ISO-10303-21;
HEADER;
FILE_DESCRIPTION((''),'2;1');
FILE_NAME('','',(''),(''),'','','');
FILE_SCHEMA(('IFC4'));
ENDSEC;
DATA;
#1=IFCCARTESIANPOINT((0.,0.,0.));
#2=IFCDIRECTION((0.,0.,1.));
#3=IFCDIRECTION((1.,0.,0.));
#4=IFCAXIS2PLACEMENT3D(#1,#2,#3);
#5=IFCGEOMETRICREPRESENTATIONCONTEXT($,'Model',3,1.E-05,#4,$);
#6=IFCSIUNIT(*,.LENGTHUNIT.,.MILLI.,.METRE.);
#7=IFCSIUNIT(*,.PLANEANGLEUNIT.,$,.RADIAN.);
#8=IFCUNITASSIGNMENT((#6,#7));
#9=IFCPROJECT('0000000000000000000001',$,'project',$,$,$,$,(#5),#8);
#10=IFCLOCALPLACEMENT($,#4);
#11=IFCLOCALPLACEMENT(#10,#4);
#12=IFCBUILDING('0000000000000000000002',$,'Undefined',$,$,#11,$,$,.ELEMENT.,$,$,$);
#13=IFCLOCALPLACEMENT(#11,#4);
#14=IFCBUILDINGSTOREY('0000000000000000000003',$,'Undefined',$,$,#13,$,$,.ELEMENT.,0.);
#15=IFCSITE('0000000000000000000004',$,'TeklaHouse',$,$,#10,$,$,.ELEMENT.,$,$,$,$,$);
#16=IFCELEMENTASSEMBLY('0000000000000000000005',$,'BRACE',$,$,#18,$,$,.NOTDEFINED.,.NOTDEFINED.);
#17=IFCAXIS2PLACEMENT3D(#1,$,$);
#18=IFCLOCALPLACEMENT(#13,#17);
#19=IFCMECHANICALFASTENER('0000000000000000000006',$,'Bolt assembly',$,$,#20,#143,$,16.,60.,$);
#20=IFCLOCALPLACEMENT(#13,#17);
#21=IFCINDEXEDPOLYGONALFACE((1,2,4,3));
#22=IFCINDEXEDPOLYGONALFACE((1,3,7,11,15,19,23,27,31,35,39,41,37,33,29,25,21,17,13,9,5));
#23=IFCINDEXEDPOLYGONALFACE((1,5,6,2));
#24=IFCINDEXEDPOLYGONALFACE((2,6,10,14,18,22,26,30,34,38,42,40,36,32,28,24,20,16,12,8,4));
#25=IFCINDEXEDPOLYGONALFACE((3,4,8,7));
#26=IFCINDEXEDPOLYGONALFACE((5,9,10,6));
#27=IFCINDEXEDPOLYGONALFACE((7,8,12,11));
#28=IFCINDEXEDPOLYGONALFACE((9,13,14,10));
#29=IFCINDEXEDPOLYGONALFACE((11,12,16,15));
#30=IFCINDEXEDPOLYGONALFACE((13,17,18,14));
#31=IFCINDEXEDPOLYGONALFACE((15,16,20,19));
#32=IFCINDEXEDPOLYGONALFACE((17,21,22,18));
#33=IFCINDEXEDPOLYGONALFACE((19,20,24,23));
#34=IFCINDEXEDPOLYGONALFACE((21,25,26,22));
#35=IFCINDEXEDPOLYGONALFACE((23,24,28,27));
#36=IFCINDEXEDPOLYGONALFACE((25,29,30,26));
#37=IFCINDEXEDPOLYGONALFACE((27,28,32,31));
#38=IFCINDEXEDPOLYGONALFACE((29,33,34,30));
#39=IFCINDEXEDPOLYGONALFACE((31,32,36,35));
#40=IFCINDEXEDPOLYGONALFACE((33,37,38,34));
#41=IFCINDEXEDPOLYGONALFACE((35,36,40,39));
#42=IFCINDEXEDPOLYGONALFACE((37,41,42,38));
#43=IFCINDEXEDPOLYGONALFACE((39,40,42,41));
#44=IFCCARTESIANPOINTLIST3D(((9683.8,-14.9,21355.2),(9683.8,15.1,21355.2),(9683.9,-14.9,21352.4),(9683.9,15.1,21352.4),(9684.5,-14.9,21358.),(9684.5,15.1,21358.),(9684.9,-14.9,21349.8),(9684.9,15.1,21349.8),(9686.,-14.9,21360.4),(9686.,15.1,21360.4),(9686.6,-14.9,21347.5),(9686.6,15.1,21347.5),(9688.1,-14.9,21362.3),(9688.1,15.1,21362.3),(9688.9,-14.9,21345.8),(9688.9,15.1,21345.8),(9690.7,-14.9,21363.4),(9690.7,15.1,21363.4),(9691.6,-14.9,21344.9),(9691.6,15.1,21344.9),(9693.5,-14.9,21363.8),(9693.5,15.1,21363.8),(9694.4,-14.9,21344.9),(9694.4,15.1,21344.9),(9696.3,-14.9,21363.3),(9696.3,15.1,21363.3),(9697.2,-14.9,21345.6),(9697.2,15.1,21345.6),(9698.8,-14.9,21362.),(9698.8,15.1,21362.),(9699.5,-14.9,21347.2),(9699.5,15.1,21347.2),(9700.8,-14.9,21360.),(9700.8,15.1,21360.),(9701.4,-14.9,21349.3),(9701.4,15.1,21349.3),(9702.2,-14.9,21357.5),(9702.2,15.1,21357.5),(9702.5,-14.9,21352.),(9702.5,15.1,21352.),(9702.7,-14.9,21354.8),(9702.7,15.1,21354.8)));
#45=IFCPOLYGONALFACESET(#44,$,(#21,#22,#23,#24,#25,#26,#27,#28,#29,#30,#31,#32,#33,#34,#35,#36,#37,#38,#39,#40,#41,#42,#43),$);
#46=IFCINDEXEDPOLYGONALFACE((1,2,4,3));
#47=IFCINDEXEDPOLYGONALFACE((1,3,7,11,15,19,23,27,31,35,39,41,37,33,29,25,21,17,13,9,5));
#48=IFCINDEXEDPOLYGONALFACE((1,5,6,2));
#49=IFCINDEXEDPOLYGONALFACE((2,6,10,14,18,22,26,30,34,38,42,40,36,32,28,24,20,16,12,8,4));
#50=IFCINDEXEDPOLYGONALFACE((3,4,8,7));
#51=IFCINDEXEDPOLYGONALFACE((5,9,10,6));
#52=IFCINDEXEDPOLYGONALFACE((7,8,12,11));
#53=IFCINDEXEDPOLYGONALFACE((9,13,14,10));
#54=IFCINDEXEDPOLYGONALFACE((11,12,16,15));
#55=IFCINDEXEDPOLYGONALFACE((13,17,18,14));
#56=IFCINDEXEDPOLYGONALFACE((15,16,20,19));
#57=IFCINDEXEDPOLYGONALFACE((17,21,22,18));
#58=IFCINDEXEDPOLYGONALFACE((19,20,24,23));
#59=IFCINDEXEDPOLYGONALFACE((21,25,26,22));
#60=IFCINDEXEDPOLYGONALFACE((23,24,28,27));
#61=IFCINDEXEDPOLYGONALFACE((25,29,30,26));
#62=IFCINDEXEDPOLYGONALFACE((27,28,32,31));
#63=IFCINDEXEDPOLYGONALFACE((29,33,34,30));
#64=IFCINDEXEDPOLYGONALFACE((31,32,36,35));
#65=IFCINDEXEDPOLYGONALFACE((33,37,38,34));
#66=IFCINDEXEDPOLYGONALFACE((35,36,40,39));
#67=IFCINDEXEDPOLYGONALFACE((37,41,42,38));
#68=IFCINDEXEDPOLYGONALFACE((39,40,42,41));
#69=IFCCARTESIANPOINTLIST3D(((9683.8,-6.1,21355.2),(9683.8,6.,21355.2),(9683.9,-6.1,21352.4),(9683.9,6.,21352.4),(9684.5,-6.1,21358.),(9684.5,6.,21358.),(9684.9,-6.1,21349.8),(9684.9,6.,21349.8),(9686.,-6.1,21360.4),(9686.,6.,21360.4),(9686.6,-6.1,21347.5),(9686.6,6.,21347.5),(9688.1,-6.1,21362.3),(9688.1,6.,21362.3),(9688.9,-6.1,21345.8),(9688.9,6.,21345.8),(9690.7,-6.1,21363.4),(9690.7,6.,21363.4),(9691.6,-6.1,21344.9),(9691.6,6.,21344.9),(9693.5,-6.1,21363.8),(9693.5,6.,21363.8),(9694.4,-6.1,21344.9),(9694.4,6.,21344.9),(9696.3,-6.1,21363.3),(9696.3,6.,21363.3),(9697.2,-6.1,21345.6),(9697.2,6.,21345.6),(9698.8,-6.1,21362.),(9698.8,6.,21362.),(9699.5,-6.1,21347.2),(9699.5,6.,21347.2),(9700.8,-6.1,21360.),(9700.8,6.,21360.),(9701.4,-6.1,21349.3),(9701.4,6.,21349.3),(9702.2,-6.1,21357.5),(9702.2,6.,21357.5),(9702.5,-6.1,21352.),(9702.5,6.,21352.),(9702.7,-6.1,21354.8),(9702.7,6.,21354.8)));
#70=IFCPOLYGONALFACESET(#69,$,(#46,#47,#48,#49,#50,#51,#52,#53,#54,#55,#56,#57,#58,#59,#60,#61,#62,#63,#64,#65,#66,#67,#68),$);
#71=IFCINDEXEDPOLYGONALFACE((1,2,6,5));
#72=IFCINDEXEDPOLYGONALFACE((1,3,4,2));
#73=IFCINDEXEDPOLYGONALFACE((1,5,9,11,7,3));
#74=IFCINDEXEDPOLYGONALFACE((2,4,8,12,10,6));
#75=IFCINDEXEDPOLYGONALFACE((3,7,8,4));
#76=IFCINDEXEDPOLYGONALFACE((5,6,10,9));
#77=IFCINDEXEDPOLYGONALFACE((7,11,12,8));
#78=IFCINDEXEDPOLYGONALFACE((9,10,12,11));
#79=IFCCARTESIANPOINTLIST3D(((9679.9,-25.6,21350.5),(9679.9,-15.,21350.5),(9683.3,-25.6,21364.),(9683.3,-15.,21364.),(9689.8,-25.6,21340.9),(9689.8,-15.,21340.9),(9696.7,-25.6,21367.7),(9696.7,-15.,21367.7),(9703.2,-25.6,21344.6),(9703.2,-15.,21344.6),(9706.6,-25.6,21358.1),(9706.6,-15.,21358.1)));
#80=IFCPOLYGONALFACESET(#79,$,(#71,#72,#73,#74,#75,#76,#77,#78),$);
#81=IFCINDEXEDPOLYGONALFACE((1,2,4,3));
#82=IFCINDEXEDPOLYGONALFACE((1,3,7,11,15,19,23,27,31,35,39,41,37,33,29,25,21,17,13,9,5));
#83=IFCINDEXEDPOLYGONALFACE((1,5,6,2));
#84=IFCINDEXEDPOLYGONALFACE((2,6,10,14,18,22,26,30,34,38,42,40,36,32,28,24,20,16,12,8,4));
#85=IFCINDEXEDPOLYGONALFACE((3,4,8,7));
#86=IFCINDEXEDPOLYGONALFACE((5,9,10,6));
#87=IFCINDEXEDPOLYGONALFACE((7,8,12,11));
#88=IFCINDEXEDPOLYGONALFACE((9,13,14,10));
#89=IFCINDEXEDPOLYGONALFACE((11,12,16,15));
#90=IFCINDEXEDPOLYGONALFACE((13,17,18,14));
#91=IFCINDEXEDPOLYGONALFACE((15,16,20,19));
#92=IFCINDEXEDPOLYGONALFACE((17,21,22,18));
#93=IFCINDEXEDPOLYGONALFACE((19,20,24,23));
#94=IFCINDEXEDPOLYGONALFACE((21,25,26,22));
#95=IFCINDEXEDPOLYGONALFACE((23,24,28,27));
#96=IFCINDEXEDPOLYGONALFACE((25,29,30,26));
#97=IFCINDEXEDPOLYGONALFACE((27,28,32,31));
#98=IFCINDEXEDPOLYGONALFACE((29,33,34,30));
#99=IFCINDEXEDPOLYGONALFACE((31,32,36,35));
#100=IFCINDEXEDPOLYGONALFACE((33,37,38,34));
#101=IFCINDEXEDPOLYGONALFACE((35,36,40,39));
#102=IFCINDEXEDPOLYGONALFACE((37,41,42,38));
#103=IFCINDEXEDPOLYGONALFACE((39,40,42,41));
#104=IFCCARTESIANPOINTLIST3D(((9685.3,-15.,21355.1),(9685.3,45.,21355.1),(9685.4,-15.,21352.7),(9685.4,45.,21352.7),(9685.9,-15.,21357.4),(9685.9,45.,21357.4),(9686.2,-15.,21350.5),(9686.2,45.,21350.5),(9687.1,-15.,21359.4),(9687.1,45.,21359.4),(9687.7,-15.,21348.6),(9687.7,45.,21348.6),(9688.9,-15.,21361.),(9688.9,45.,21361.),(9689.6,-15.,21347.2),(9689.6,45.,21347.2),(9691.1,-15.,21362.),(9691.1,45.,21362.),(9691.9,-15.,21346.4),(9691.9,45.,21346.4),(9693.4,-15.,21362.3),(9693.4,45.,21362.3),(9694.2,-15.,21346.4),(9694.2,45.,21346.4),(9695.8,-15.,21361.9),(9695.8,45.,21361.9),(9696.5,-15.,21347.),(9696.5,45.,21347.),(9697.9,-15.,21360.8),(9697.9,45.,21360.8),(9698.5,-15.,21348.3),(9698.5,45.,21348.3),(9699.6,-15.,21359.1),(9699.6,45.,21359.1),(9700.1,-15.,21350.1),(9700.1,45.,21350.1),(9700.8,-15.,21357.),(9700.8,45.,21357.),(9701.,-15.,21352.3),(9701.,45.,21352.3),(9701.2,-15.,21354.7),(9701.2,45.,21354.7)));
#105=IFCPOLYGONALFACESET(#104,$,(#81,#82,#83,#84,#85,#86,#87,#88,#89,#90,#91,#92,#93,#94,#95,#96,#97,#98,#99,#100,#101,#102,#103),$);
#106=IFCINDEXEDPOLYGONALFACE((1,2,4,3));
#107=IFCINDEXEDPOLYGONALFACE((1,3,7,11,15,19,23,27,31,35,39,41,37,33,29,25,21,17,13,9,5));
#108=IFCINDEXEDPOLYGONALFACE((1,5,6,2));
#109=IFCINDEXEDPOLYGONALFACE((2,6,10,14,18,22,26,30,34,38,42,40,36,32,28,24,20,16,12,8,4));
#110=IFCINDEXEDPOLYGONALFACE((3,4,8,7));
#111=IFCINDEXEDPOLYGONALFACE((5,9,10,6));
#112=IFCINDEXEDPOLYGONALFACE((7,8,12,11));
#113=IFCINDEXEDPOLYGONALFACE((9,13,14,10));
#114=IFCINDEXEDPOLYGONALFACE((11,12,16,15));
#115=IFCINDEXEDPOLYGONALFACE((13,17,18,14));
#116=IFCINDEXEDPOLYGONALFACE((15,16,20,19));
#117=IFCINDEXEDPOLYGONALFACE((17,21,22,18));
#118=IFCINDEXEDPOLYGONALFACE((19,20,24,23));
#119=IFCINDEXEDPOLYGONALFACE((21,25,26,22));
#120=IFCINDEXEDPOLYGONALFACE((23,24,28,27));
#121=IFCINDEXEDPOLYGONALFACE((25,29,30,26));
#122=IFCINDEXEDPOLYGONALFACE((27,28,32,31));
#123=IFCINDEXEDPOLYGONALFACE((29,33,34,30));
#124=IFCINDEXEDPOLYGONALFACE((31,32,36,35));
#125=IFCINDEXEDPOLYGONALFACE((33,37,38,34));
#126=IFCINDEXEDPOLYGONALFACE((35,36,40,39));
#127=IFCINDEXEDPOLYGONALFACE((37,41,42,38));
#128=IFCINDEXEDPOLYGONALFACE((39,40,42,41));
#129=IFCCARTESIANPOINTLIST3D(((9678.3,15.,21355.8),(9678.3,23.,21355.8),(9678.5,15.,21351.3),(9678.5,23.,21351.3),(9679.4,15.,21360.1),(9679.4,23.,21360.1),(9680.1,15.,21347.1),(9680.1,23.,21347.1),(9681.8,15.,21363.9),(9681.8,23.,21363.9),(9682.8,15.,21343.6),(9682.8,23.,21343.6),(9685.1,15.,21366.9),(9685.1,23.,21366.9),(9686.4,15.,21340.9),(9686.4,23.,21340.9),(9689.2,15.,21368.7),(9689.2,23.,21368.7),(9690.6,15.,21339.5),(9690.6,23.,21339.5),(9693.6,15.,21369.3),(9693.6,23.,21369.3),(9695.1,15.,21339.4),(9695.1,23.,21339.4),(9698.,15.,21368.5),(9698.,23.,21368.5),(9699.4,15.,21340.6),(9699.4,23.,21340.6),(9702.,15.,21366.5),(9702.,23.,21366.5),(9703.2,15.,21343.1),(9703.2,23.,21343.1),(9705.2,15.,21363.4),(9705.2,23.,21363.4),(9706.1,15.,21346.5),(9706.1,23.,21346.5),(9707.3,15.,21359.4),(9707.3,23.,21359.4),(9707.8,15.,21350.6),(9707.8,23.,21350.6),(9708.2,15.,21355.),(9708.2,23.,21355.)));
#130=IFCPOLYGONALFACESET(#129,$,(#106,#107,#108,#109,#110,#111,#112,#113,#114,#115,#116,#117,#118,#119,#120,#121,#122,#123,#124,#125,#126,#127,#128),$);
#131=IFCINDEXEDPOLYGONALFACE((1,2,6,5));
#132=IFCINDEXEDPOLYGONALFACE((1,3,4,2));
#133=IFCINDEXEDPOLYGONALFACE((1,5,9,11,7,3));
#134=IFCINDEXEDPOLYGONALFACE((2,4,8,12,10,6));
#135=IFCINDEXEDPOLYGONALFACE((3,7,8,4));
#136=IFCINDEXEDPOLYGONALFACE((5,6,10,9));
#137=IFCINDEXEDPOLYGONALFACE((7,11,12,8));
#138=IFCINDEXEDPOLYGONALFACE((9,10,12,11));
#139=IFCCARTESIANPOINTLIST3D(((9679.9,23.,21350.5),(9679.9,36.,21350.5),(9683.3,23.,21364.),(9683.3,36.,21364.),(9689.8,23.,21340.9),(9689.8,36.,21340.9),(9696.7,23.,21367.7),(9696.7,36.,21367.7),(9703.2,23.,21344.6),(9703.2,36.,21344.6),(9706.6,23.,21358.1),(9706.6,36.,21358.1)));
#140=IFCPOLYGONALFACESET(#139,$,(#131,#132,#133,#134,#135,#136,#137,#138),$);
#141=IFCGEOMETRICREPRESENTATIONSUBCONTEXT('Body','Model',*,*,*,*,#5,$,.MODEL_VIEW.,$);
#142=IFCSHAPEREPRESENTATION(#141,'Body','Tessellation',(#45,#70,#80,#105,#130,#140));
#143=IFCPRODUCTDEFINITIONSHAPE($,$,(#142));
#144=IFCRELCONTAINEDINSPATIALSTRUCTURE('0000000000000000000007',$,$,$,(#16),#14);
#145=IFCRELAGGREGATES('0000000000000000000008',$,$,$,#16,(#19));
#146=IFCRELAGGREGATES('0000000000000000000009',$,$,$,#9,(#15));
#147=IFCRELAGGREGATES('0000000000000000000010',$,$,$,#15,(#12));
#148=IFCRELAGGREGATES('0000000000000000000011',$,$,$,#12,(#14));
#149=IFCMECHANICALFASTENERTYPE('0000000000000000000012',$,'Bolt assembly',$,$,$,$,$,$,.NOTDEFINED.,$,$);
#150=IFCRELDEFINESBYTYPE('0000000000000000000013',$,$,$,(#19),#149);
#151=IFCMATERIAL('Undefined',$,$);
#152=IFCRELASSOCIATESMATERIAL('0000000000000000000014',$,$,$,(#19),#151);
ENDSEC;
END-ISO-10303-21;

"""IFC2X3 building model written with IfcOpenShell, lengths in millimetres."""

from ifc_helpers import new_model, si_unit, frame, origin_with_axes, origin_2d_with_axis, place, context, subcontext, project, spatial, polyline, circle, outline, extrude, source, transform, mapped, material, type_object, element, aggregate, save


model = new_model("IFC2X3")

# Units and contexts
model_context = context("Model", 3, precision=1e-05, world=origin_with_axes())
body_context = subcontext(model_context, "Body", "Model", "MODEL_VIEW")
ifc_project = project(units=[si_unit("LENGTHUNIT", "METRE", prefix="MILLI"), si_unit("PLANEANGLEUNIT", "RADIAN")], contexts=[model_context])

# Site, building, storey
site_placement = place(None, origin_with_axes())
site = spatial("IfcSite", under=ifc_project, at=site_placement, Name="TeklaHouse", CompositionType="ELEMENT")
building_placement = place(site_placement, origin_with_axes())
building = spatial("IfcBuilding", under=site, at=building_placement, Name="Undefined", CompositionType="ELEMENT")
storey_placement = place(building_placement, origin_with_axes())
storey = spatial("IfcBuildingStorey", under=building, at=storey_placement, Name="Undefined", CompositionType="ELEMENT", Elevation=0.0)

# Element assembly
assembly_1_placement = place(storey_placement, origin_with_axes())
assembly_1 = element("IfcElementAssembly", 1, at=assembly_1_placement, inside=storey, Name="BRACE", AssemblyPlace="NOTDEFINED", PredefinedType="NOTDEFINED")

# Shared definitions
ifc_material_1 = material(Name="Undefined")
mechanical_fastener_type = type_object("IfcMechanicalFastenerType", Name="Bolt assembly")

# Mechanical fastener
shared_shape_1 = source(origin_with_axes(), body_context, "Body", "SweptSolid", [
    extrude(circle(Radius=9.5, at=origin_2d_with_axis()), frame((0.0, -14.9, 0.0), z_axis=(0.0, 1.0, 0.0), x_axis=(1.0, 0.0, 0.0)), (0.0, 0.0, 1.0), 30.0),
    extrude(circle(Radius=9.5, at=origin_2d_with_axis()), frame((0.0, -6.1, 0.0), z_axis=(0.0, 1.0, 0.0), x_axis=(1.0, 0.0, 0.0)), (0.0, 0.0, 1.0), 12.1),
    extrude(outline(polyline([(12.0, -6.9), (12.0, 6.9), (0.0, 13.9), (-12.0, 6.9), (-12.0, -6.9), (0.0, -13.9), (12.0, -6.9)])), frame((0.0, -25.6, 0.0), z_axis=(0.0, 1.0, 0.0), x_axis=(1.0, 0.0, 0.0)), (0.0, 0.0, 1.0), 10.6),
    extrude(circle(Radius=8.0, at=origin_2d_with_axis()), frame((0.0, -15.0, 0.0), z_axis=(0.0, 1.0, 0.0), x_axis=(1.0, 0.0, 0.0)), (0.0, 0.0, 1.0), 60.0),
    extrude(circle(Radius=15.0, at=origin_2d_with_axis()), frame((0.0, 15.0, 0.0), z_axis=(0.0, 1.0, 0.0), x_axis=(1.0, 0.0, 0.0)), (0.0, 0.0, 1.0), 8.0),
    extrude(outline(polyline([(12.0, -6.9), (12.0, 6.9), (0.0, 13.9), (-12.0, 6.9), (-12.0, -6.9), (0.0, -13.9), (12.0, -6.9)])), frame((0.0, 23.0, 0.0), z_axis=(0.0, 1.0, 0.0), x_axis=(1.0, 0.0, 0.0)), (0.0, 0.0, 1.0), 13.0),
])
mechanical_fastener_1_placement = place(assembly_1_placement, frame((9693.2, 0.0, 21354.3), z_axis=(0.716, 0.0, -0.6981), x_axis=(-0.6981, 0.0, -0.716)))
mechanical_fastener_1 = element("IfcMechanicalFastener", 2, at=mechanical_fastener_1_placement, type_object=mechanical_fastener_type, material=ifc_material_1, Name="Bolt assembly", NominalDiameter=16.0, NominalLength=60.0, context=body_context, shape_type="MappedRepresentation", body=[
    mapped(shared_shape_1, transform((0.0, 0.0, 0.0))),
])
aggregate(assembly_1, [mechanical_fastener_1])

save(model, "model.ifc")
